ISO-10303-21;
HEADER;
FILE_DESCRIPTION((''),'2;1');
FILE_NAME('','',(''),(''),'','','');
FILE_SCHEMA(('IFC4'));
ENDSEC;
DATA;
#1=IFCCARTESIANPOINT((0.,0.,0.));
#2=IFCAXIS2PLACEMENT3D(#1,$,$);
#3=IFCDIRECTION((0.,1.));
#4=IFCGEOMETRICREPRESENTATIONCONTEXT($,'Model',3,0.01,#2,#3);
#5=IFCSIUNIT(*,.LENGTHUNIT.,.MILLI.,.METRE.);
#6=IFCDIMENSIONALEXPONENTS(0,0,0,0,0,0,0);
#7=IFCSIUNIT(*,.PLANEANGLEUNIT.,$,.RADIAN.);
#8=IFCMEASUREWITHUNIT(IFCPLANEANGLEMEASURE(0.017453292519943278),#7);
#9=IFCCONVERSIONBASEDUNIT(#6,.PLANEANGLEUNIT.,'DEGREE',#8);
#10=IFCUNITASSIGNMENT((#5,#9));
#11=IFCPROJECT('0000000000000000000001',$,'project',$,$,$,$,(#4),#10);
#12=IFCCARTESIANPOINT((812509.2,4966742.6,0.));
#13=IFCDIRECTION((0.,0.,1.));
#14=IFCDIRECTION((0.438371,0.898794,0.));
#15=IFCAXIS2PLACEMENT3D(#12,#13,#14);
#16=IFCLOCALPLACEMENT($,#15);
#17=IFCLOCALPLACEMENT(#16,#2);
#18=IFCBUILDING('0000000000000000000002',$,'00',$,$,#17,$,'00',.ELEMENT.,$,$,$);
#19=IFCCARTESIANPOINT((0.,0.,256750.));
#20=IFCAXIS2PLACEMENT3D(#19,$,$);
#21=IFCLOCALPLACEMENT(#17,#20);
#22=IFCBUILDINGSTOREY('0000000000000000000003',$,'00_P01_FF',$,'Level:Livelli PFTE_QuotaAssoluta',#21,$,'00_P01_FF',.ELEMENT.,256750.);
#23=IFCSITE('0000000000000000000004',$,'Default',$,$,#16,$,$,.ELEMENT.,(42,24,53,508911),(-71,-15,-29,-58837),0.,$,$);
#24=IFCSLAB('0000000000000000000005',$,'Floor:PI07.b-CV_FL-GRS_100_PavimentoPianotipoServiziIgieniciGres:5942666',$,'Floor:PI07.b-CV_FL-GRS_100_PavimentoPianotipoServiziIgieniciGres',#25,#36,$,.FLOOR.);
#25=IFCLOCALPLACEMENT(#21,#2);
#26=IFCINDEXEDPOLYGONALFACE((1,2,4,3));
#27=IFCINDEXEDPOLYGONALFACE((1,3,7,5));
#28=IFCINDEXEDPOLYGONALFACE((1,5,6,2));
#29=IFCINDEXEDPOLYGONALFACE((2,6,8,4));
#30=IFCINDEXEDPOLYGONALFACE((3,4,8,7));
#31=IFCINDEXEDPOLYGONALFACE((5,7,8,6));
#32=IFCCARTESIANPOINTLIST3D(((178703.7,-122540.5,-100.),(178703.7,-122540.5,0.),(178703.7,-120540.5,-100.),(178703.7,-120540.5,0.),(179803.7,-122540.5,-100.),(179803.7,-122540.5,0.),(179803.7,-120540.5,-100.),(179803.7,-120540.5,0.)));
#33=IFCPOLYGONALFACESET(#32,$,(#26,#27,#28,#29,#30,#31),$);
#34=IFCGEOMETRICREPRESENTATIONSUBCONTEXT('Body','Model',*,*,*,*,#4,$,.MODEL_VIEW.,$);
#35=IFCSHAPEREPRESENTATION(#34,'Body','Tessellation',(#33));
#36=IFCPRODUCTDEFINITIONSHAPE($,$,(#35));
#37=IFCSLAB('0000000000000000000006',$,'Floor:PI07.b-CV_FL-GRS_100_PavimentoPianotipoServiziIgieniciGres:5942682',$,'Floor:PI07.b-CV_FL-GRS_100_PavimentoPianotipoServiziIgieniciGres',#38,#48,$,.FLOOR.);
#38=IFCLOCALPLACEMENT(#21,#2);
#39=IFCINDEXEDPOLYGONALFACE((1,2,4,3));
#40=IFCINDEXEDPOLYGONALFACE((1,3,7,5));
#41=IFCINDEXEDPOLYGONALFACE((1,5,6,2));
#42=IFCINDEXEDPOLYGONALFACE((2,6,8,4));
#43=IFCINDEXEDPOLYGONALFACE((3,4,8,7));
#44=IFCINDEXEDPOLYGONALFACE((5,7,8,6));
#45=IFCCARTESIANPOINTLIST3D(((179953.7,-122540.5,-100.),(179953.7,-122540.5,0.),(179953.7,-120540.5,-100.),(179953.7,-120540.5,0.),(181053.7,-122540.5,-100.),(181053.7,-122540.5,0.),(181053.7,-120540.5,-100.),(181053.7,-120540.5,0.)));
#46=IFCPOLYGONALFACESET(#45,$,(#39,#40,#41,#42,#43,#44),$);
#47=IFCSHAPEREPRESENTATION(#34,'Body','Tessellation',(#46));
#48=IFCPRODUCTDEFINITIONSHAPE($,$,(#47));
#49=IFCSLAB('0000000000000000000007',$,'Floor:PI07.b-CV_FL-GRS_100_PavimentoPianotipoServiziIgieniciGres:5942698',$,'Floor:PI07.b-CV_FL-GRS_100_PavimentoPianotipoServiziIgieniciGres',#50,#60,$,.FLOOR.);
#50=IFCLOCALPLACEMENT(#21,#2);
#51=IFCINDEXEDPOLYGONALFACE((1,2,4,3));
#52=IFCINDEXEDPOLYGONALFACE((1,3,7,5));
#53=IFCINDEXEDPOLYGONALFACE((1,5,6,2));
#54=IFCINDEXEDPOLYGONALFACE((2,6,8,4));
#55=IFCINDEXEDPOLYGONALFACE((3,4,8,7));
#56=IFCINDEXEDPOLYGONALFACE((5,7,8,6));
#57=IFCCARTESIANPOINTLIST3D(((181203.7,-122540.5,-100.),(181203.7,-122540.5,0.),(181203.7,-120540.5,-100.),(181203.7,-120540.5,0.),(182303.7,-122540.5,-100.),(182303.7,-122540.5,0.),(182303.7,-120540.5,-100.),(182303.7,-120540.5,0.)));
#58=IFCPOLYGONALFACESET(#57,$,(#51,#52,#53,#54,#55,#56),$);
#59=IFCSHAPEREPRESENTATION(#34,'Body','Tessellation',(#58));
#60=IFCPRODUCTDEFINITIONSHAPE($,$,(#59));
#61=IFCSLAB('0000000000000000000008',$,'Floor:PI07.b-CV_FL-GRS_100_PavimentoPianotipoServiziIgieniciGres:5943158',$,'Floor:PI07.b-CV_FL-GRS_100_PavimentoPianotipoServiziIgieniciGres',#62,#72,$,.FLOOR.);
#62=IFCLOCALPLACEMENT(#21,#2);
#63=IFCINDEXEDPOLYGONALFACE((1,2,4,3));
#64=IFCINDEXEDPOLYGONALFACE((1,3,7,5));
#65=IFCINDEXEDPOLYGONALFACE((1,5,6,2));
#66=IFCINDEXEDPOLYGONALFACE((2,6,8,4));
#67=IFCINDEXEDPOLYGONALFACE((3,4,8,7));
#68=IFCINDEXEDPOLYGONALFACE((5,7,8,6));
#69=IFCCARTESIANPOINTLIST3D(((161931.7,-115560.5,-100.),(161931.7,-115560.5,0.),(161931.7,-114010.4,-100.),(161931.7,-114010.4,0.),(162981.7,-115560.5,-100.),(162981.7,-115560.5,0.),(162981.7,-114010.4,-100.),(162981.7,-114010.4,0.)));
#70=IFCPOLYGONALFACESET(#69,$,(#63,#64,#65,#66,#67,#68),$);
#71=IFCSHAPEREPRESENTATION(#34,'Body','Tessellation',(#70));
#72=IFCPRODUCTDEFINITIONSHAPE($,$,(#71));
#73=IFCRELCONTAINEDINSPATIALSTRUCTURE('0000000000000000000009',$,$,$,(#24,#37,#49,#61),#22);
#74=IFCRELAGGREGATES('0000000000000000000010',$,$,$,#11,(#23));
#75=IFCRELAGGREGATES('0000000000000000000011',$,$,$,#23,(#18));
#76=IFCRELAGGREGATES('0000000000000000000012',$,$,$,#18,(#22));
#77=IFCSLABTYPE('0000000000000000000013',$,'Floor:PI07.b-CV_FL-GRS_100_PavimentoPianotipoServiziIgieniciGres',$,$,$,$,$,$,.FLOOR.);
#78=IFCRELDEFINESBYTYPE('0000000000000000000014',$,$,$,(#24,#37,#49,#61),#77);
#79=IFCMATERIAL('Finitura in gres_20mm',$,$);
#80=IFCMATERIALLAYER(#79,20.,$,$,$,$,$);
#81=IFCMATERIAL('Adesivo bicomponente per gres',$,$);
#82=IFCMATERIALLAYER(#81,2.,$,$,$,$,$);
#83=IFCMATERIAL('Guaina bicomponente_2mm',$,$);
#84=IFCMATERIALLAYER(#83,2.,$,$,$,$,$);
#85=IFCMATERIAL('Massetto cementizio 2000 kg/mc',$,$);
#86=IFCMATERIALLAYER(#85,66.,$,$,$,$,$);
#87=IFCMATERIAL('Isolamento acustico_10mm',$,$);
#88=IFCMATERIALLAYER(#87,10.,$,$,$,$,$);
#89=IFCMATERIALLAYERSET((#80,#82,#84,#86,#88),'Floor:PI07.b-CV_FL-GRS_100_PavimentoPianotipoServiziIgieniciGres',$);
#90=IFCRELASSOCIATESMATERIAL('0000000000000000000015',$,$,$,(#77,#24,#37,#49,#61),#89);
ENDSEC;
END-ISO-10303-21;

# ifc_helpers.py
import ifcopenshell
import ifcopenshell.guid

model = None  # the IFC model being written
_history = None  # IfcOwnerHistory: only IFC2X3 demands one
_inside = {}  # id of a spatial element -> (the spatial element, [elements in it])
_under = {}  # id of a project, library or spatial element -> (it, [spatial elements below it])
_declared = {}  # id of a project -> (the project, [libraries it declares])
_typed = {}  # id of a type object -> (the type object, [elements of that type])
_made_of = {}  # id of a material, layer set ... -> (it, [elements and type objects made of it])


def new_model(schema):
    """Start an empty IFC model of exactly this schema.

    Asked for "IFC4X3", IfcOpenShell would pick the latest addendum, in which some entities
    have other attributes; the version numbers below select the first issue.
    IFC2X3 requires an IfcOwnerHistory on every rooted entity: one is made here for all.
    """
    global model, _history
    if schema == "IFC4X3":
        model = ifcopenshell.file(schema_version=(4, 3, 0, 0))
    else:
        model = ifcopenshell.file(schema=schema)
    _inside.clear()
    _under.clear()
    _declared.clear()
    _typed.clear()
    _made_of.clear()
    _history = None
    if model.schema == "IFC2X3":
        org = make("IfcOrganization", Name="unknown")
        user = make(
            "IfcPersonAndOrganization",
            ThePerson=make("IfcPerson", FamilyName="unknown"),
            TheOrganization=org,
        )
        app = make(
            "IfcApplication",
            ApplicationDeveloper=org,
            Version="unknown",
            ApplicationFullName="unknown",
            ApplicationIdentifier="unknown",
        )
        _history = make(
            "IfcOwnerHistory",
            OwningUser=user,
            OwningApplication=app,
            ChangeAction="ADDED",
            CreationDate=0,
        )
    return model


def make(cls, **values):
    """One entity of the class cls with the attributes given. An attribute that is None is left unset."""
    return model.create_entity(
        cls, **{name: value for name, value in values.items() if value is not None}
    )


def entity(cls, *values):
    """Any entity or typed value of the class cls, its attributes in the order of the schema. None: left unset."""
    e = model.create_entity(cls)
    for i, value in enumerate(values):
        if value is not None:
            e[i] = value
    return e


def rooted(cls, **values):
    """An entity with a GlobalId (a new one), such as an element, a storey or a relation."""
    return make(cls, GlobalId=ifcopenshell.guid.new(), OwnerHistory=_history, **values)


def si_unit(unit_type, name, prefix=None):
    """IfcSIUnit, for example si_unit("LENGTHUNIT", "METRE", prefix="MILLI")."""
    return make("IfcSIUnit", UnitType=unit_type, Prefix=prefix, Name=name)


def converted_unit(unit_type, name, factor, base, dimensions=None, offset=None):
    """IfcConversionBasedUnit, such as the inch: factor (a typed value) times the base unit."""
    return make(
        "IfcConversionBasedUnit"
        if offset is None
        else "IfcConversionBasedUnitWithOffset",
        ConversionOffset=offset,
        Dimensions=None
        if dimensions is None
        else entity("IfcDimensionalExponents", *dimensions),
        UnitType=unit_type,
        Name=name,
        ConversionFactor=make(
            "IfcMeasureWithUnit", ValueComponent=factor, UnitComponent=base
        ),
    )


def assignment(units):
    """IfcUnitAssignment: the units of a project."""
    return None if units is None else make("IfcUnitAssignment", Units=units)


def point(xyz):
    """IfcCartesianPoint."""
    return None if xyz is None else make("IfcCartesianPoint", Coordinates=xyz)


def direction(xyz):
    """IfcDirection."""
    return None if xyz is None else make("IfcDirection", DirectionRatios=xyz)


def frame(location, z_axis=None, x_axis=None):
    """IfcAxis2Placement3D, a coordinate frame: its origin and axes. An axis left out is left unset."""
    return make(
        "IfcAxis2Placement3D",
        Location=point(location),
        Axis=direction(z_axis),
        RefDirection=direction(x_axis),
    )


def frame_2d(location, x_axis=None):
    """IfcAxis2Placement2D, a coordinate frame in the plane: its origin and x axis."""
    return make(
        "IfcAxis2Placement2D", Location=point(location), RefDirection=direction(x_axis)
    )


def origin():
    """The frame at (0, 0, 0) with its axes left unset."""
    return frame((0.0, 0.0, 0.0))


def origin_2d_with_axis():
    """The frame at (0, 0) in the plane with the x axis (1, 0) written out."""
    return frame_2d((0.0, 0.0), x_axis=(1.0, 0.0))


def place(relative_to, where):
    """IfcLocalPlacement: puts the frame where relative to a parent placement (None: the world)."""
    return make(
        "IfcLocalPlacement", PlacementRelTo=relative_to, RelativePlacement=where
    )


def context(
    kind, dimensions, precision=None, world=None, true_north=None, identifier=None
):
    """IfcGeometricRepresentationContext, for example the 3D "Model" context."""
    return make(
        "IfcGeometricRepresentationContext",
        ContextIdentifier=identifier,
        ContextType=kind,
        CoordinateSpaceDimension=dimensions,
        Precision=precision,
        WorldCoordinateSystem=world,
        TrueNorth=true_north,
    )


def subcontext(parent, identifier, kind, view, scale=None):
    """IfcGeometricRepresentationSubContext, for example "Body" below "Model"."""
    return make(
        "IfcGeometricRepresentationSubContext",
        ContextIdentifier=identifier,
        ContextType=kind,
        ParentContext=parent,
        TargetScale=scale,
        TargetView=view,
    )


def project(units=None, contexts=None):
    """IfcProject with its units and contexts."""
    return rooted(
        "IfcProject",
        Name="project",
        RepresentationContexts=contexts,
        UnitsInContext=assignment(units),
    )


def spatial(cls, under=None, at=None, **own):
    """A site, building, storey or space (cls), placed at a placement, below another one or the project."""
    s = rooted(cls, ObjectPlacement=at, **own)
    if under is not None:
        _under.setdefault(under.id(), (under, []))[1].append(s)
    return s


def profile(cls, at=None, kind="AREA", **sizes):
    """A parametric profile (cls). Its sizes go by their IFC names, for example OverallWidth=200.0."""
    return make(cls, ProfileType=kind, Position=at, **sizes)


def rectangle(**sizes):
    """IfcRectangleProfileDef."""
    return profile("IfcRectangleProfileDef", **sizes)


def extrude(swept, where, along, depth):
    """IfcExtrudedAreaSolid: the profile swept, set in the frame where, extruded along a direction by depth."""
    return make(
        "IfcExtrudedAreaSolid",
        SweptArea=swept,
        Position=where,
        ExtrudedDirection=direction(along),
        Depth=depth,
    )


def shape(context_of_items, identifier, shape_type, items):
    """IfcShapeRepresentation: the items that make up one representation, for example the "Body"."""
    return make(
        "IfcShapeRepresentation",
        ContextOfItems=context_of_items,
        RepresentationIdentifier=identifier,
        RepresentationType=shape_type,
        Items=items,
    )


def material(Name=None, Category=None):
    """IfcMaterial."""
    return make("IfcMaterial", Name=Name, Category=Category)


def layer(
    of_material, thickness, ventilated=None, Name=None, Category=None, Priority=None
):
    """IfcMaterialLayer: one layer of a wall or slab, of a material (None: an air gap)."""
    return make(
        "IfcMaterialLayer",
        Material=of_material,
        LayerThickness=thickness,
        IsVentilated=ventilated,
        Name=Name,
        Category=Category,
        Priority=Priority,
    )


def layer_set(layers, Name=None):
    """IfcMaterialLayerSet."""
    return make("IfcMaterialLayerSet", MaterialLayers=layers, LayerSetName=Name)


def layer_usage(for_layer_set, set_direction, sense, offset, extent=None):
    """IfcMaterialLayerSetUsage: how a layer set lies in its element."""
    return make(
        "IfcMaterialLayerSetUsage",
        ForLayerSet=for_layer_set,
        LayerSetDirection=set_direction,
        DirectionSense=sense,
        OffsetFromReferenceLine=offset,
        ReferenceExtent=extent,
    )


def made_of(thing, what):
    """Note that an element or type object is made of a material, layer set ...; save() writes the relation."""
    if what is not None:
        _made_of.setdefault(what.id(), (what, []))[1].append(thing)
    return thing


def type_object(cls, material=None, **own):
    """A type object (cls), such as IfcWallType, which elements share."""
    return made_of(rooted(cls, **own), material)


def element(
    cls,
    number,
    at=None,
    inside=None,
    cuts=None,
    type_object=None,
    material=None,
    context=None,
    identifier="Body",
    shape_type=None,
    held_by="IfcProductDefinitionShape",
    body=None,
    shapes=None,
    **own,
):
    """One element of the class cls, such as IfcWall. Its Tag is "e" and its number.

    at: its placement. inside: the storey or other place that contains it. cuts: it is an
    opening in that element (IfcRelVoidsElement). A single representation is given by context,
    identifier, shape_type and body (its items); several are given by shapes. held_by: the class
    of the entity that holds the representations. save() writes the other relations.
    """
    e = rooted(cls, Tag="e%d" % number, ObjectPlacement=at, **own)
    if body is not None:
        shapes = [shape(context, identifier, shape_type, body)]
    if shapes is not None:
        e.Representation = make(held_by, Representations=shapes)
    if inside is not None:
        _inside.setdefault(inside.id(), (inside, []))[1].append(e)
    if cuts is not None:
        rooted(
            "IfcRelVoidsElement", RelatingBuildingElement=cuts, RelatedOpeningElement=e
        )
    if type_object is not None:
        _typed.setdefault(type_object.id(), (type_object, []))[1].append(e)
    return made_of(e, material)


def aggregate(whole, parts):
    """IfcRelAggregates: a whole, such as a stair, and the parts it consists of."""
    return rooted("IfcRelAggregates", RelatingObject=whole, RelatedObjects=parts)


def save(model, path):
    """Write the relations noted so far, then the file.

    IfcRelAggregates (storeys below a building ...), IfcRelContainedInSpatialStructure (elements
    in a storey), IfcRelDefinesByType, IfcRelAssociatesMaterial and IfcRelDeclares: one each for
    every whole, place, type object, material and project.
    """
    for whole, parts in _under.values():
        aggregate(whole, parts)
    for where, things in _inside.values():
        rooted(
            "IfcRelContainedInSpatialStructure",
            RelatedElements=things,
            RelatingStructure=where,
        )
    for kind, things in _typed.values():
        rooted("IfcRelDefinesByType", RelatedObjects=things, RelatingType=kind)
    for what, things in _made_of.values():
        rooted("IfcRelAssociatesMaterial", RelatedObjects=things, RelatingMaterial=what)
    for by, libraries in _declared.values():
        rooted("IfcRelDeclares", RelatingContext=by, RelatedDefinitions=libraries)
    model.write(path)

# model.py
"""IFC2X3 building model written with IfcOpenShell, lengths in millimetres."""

from ifc_helpers import new_model, entity, si_unit, converted_unit, direction, frame, frame_2d, origin, origin_2d_with_axis, place, context, subcontext, project, spatial, rectangle, extrude, material, layer, layer_set, layer_usage, type_object, element, save


model = new_model("IFC2X3")

# Units and contexts
model_context = context("Model", 3, precision=0.01, world=origin(), true_north=direction((0.0, 1.0)))
body_context = subcontext(model_context, "Body", "Model", "MODEL_VIEW")
ifc_project = project(units=[si_unit("LENGTHUNIT", "METRE", prefix="MILLI"), converted_unit("PLANEANGLEUNIT", "DEGREE", entity("IfcPlaneAngleMeasure", 0.017453292519943278), si_unit("PLANEANGLEUNIT", "RADIAN"), dimensions=[0, 0, 0, 0, 0, 0, 0])], contexts=[model_context])

# Site, building, storey
site_placement = place(None, frame((812509.2, 4966742.6, 0.0), z_axis=(0.0, 0.0, 1.0), x_axis=(0.438371, 0.898794, 0.0)))
site = spatial("IfcSite", under=ifc_project, at=site_placement, Name="Default", CompositionType="ELEMENT", RefLatitude=(42, 24, 53, 508911), RefLongitude=(-71, -15, -29, -58837), RefElevation=0.0)
building_placement = place(site_placement, origin())
building = spatial("IfcBuilding", under=site, at=building_placement, Name="00", LongName="00", CompositionType="ELEMENT")
storey_placement = place(building_placement, frame((0.0, 0.0, 256750.0)))
storey = spatial("IfcBuildingStorey", under=building, at=storey_placement, Name="00_P01_FF", ObjectType="Level:Livelli PFTE_QuotaAssoluta", LongName="00_P01_FF", CompositionType="ELEMENT", Elevation=256750.0)

# Slabs
ifc_material_1 = material(Name="Massetto cementizio 2000 kg/mc")
ifc_material_2 = material(Name="Isolamento acustico_10mm")
ifc_material_3 = material(Name="Finitura in gres_20mm")
ifc_layer_1 = layer(ifc_material_3, 20.0)
ifc_material_4 = material(Name="Adesivo bicomponente per gres")
ifc_layer_2 = layer(ifc_material_4, 2.0)
ifc_material_5 = material(Name="Guaina bicomponente_2mm")
ifc_layer_3 = layer(ifc_material_5, 2.0)
ifc_layer_4 = layer(ifc_material_1, 66.0)
ifc_layer_5 = layer(ifc_material_2, 10.0)
ifc_layer_set_1 = layer_set([ifc_layer_1, ifc_layer_2, ifc_layer_3, ifc_layer_4, ifc_layer_5], Name="Floor:PI07.b-CV_FL-GRS_100_PavimentoPianotipoServiziIgieniciGres")
ifc_layer_usage_1 = layer_usage(ifc_layer_set_1, "AXIS3", "POSITIVE", 0.0)
slab_type_1 = type_object("IfcSlabType", Name="Floor:PI07.b-CV_FL-GRS_100_PavimentoPianotipoServiziIgieniciGres", PredefinedType="FLOOR", material=ifc_layer_set_1)
slab_1_placement = place(storey_placement, origin())
element("IfcSlab", 1, at=slab_1_placement, inside=storey, type_object=slab_type_1, material=ifc_layer_usage_1, Name="Floor:PI07.b-CV_FL-GRS_100_PavimentoPianotipoServiziIgieniciGres:5942666", ObjectType="Floor:PI07.b-CV_FL-GRS_100_PavimentoPianotipoServiziIgieniciGres", PredefinedType="FLOOR", context=body_context, shape_type="SweptSolid", body=[
    extrude(rectangle(XDim=2000.0, YDim=1100.0, at=frame_2d((0.0, 0.0), x_axis=(1.0, 0.0))), frame((179253.7, -121540.5, 0.0), z_axis=(0.0, 0.0, -1.0), x_axis=(0.0, 1.0, 0.0)), (0.0, 0.0, 1.0), 100.0),
])
ifc_layer_usage_2 = layer_usage(ifc_layer_set_1, "AXIS3", "POSITIVE", 0.0)
slab_2_placement = place(storey_placement, origin())
element("IfcSlab", 2, at=slab_2_placement, inside=storey, type_object=slab_type_1, material=ifc_layer_usage_2, Name="Floor:PI07.b-CV_FL-GRS_100_PavimentoPianotipoServiziIgieniciGres:5942682", ObjectType="Floor:PI07.b-CV_FL-GRS_100_PavimentoPianotipoServiziIgieniciGres", PredefinedType="FLOOR", context=body_context, shape_type="SweptSolid", body=[
    extrude(rectangle(XDim=2000.0, YDim=1100.0, at=frame_2d((0.0, 0.0), x_axis=(1.0, 0.0))), frame((180503.7, -121540.5, 0.0), z_axis=(0.0, 0.0, -1.0), x_axis=(0.0, 1.0, 0.0)), (0.0, 0.0, 1.0), 100.0),
])
ifc_layer_usage_3 = layer_usage(ifc_layer_set_1, "AXIS3", "POSITIVE", 0.0)
slab_3_placement = place(storey_placement, origin())
element("IfcSlab", 3, at=slab_3_placement, inside=storey, type_object=slab_type_1, material=ifc_layer_usage_3, Name="Floor:PI07.b-CV_FL-GRS_100_PavimentoPianotipoServiziIgieniciGres:5942698", ObjectType="Floor:PI07.b-CV_FL-GRS_100_PavimentoPianotipoServiziIgieniciGres", PredefinedType="FLOOR", context=body_context, shape_type="SweptSolid", body=[
    extrude(rectangle(XDim=2000.0, YDim=1100.0, at=frame_2d((0.0, 0.0), x_axis=(1.0, 0.0))), frame((181753.7, -121540.5, 0.0), z_axis=(0.0, 0.0, -1.0), x_axis=(0.0, 1.0, 0.0)), (0.0, 0.0, 1.0), 100.0),
])
ifc_layer_usage_4 = layer_usage(ifc_layer_set_1, "AXIS3", "POSITIVE", 0.0)
slab_4_placement = place(storey_placement, origin())
element("IfcSlab", 4, at=slab_4_placement, inside=storey, type_object=slab_type_1, material=ifc_layer_usage_4, Name="Floor:PI07.b-CV_FL-GRS_100_PavimentoPianotipoServiziIgieniciGres:5943158", ObjectType="Floor:PI07.b-CV_FL-GRS_100_PavimentoPianotipoServiziIgieniciGres", PredefinedType="FLOOR", context=body_context, shape_type="SweptSolid", body=[
    extrude(rectangle(XDim=1050.0, YDim=1550.1, at=origin_2d_with_axis()), frame((162456.7, -114785.4, 0.0), z_axis=(0.0, 0.0, -1.0), x_axis=(1.0, 0.0, 0.0)), (0.0, 0.0, 1.0), 100.0),
])

save(model, "model.ifc")
